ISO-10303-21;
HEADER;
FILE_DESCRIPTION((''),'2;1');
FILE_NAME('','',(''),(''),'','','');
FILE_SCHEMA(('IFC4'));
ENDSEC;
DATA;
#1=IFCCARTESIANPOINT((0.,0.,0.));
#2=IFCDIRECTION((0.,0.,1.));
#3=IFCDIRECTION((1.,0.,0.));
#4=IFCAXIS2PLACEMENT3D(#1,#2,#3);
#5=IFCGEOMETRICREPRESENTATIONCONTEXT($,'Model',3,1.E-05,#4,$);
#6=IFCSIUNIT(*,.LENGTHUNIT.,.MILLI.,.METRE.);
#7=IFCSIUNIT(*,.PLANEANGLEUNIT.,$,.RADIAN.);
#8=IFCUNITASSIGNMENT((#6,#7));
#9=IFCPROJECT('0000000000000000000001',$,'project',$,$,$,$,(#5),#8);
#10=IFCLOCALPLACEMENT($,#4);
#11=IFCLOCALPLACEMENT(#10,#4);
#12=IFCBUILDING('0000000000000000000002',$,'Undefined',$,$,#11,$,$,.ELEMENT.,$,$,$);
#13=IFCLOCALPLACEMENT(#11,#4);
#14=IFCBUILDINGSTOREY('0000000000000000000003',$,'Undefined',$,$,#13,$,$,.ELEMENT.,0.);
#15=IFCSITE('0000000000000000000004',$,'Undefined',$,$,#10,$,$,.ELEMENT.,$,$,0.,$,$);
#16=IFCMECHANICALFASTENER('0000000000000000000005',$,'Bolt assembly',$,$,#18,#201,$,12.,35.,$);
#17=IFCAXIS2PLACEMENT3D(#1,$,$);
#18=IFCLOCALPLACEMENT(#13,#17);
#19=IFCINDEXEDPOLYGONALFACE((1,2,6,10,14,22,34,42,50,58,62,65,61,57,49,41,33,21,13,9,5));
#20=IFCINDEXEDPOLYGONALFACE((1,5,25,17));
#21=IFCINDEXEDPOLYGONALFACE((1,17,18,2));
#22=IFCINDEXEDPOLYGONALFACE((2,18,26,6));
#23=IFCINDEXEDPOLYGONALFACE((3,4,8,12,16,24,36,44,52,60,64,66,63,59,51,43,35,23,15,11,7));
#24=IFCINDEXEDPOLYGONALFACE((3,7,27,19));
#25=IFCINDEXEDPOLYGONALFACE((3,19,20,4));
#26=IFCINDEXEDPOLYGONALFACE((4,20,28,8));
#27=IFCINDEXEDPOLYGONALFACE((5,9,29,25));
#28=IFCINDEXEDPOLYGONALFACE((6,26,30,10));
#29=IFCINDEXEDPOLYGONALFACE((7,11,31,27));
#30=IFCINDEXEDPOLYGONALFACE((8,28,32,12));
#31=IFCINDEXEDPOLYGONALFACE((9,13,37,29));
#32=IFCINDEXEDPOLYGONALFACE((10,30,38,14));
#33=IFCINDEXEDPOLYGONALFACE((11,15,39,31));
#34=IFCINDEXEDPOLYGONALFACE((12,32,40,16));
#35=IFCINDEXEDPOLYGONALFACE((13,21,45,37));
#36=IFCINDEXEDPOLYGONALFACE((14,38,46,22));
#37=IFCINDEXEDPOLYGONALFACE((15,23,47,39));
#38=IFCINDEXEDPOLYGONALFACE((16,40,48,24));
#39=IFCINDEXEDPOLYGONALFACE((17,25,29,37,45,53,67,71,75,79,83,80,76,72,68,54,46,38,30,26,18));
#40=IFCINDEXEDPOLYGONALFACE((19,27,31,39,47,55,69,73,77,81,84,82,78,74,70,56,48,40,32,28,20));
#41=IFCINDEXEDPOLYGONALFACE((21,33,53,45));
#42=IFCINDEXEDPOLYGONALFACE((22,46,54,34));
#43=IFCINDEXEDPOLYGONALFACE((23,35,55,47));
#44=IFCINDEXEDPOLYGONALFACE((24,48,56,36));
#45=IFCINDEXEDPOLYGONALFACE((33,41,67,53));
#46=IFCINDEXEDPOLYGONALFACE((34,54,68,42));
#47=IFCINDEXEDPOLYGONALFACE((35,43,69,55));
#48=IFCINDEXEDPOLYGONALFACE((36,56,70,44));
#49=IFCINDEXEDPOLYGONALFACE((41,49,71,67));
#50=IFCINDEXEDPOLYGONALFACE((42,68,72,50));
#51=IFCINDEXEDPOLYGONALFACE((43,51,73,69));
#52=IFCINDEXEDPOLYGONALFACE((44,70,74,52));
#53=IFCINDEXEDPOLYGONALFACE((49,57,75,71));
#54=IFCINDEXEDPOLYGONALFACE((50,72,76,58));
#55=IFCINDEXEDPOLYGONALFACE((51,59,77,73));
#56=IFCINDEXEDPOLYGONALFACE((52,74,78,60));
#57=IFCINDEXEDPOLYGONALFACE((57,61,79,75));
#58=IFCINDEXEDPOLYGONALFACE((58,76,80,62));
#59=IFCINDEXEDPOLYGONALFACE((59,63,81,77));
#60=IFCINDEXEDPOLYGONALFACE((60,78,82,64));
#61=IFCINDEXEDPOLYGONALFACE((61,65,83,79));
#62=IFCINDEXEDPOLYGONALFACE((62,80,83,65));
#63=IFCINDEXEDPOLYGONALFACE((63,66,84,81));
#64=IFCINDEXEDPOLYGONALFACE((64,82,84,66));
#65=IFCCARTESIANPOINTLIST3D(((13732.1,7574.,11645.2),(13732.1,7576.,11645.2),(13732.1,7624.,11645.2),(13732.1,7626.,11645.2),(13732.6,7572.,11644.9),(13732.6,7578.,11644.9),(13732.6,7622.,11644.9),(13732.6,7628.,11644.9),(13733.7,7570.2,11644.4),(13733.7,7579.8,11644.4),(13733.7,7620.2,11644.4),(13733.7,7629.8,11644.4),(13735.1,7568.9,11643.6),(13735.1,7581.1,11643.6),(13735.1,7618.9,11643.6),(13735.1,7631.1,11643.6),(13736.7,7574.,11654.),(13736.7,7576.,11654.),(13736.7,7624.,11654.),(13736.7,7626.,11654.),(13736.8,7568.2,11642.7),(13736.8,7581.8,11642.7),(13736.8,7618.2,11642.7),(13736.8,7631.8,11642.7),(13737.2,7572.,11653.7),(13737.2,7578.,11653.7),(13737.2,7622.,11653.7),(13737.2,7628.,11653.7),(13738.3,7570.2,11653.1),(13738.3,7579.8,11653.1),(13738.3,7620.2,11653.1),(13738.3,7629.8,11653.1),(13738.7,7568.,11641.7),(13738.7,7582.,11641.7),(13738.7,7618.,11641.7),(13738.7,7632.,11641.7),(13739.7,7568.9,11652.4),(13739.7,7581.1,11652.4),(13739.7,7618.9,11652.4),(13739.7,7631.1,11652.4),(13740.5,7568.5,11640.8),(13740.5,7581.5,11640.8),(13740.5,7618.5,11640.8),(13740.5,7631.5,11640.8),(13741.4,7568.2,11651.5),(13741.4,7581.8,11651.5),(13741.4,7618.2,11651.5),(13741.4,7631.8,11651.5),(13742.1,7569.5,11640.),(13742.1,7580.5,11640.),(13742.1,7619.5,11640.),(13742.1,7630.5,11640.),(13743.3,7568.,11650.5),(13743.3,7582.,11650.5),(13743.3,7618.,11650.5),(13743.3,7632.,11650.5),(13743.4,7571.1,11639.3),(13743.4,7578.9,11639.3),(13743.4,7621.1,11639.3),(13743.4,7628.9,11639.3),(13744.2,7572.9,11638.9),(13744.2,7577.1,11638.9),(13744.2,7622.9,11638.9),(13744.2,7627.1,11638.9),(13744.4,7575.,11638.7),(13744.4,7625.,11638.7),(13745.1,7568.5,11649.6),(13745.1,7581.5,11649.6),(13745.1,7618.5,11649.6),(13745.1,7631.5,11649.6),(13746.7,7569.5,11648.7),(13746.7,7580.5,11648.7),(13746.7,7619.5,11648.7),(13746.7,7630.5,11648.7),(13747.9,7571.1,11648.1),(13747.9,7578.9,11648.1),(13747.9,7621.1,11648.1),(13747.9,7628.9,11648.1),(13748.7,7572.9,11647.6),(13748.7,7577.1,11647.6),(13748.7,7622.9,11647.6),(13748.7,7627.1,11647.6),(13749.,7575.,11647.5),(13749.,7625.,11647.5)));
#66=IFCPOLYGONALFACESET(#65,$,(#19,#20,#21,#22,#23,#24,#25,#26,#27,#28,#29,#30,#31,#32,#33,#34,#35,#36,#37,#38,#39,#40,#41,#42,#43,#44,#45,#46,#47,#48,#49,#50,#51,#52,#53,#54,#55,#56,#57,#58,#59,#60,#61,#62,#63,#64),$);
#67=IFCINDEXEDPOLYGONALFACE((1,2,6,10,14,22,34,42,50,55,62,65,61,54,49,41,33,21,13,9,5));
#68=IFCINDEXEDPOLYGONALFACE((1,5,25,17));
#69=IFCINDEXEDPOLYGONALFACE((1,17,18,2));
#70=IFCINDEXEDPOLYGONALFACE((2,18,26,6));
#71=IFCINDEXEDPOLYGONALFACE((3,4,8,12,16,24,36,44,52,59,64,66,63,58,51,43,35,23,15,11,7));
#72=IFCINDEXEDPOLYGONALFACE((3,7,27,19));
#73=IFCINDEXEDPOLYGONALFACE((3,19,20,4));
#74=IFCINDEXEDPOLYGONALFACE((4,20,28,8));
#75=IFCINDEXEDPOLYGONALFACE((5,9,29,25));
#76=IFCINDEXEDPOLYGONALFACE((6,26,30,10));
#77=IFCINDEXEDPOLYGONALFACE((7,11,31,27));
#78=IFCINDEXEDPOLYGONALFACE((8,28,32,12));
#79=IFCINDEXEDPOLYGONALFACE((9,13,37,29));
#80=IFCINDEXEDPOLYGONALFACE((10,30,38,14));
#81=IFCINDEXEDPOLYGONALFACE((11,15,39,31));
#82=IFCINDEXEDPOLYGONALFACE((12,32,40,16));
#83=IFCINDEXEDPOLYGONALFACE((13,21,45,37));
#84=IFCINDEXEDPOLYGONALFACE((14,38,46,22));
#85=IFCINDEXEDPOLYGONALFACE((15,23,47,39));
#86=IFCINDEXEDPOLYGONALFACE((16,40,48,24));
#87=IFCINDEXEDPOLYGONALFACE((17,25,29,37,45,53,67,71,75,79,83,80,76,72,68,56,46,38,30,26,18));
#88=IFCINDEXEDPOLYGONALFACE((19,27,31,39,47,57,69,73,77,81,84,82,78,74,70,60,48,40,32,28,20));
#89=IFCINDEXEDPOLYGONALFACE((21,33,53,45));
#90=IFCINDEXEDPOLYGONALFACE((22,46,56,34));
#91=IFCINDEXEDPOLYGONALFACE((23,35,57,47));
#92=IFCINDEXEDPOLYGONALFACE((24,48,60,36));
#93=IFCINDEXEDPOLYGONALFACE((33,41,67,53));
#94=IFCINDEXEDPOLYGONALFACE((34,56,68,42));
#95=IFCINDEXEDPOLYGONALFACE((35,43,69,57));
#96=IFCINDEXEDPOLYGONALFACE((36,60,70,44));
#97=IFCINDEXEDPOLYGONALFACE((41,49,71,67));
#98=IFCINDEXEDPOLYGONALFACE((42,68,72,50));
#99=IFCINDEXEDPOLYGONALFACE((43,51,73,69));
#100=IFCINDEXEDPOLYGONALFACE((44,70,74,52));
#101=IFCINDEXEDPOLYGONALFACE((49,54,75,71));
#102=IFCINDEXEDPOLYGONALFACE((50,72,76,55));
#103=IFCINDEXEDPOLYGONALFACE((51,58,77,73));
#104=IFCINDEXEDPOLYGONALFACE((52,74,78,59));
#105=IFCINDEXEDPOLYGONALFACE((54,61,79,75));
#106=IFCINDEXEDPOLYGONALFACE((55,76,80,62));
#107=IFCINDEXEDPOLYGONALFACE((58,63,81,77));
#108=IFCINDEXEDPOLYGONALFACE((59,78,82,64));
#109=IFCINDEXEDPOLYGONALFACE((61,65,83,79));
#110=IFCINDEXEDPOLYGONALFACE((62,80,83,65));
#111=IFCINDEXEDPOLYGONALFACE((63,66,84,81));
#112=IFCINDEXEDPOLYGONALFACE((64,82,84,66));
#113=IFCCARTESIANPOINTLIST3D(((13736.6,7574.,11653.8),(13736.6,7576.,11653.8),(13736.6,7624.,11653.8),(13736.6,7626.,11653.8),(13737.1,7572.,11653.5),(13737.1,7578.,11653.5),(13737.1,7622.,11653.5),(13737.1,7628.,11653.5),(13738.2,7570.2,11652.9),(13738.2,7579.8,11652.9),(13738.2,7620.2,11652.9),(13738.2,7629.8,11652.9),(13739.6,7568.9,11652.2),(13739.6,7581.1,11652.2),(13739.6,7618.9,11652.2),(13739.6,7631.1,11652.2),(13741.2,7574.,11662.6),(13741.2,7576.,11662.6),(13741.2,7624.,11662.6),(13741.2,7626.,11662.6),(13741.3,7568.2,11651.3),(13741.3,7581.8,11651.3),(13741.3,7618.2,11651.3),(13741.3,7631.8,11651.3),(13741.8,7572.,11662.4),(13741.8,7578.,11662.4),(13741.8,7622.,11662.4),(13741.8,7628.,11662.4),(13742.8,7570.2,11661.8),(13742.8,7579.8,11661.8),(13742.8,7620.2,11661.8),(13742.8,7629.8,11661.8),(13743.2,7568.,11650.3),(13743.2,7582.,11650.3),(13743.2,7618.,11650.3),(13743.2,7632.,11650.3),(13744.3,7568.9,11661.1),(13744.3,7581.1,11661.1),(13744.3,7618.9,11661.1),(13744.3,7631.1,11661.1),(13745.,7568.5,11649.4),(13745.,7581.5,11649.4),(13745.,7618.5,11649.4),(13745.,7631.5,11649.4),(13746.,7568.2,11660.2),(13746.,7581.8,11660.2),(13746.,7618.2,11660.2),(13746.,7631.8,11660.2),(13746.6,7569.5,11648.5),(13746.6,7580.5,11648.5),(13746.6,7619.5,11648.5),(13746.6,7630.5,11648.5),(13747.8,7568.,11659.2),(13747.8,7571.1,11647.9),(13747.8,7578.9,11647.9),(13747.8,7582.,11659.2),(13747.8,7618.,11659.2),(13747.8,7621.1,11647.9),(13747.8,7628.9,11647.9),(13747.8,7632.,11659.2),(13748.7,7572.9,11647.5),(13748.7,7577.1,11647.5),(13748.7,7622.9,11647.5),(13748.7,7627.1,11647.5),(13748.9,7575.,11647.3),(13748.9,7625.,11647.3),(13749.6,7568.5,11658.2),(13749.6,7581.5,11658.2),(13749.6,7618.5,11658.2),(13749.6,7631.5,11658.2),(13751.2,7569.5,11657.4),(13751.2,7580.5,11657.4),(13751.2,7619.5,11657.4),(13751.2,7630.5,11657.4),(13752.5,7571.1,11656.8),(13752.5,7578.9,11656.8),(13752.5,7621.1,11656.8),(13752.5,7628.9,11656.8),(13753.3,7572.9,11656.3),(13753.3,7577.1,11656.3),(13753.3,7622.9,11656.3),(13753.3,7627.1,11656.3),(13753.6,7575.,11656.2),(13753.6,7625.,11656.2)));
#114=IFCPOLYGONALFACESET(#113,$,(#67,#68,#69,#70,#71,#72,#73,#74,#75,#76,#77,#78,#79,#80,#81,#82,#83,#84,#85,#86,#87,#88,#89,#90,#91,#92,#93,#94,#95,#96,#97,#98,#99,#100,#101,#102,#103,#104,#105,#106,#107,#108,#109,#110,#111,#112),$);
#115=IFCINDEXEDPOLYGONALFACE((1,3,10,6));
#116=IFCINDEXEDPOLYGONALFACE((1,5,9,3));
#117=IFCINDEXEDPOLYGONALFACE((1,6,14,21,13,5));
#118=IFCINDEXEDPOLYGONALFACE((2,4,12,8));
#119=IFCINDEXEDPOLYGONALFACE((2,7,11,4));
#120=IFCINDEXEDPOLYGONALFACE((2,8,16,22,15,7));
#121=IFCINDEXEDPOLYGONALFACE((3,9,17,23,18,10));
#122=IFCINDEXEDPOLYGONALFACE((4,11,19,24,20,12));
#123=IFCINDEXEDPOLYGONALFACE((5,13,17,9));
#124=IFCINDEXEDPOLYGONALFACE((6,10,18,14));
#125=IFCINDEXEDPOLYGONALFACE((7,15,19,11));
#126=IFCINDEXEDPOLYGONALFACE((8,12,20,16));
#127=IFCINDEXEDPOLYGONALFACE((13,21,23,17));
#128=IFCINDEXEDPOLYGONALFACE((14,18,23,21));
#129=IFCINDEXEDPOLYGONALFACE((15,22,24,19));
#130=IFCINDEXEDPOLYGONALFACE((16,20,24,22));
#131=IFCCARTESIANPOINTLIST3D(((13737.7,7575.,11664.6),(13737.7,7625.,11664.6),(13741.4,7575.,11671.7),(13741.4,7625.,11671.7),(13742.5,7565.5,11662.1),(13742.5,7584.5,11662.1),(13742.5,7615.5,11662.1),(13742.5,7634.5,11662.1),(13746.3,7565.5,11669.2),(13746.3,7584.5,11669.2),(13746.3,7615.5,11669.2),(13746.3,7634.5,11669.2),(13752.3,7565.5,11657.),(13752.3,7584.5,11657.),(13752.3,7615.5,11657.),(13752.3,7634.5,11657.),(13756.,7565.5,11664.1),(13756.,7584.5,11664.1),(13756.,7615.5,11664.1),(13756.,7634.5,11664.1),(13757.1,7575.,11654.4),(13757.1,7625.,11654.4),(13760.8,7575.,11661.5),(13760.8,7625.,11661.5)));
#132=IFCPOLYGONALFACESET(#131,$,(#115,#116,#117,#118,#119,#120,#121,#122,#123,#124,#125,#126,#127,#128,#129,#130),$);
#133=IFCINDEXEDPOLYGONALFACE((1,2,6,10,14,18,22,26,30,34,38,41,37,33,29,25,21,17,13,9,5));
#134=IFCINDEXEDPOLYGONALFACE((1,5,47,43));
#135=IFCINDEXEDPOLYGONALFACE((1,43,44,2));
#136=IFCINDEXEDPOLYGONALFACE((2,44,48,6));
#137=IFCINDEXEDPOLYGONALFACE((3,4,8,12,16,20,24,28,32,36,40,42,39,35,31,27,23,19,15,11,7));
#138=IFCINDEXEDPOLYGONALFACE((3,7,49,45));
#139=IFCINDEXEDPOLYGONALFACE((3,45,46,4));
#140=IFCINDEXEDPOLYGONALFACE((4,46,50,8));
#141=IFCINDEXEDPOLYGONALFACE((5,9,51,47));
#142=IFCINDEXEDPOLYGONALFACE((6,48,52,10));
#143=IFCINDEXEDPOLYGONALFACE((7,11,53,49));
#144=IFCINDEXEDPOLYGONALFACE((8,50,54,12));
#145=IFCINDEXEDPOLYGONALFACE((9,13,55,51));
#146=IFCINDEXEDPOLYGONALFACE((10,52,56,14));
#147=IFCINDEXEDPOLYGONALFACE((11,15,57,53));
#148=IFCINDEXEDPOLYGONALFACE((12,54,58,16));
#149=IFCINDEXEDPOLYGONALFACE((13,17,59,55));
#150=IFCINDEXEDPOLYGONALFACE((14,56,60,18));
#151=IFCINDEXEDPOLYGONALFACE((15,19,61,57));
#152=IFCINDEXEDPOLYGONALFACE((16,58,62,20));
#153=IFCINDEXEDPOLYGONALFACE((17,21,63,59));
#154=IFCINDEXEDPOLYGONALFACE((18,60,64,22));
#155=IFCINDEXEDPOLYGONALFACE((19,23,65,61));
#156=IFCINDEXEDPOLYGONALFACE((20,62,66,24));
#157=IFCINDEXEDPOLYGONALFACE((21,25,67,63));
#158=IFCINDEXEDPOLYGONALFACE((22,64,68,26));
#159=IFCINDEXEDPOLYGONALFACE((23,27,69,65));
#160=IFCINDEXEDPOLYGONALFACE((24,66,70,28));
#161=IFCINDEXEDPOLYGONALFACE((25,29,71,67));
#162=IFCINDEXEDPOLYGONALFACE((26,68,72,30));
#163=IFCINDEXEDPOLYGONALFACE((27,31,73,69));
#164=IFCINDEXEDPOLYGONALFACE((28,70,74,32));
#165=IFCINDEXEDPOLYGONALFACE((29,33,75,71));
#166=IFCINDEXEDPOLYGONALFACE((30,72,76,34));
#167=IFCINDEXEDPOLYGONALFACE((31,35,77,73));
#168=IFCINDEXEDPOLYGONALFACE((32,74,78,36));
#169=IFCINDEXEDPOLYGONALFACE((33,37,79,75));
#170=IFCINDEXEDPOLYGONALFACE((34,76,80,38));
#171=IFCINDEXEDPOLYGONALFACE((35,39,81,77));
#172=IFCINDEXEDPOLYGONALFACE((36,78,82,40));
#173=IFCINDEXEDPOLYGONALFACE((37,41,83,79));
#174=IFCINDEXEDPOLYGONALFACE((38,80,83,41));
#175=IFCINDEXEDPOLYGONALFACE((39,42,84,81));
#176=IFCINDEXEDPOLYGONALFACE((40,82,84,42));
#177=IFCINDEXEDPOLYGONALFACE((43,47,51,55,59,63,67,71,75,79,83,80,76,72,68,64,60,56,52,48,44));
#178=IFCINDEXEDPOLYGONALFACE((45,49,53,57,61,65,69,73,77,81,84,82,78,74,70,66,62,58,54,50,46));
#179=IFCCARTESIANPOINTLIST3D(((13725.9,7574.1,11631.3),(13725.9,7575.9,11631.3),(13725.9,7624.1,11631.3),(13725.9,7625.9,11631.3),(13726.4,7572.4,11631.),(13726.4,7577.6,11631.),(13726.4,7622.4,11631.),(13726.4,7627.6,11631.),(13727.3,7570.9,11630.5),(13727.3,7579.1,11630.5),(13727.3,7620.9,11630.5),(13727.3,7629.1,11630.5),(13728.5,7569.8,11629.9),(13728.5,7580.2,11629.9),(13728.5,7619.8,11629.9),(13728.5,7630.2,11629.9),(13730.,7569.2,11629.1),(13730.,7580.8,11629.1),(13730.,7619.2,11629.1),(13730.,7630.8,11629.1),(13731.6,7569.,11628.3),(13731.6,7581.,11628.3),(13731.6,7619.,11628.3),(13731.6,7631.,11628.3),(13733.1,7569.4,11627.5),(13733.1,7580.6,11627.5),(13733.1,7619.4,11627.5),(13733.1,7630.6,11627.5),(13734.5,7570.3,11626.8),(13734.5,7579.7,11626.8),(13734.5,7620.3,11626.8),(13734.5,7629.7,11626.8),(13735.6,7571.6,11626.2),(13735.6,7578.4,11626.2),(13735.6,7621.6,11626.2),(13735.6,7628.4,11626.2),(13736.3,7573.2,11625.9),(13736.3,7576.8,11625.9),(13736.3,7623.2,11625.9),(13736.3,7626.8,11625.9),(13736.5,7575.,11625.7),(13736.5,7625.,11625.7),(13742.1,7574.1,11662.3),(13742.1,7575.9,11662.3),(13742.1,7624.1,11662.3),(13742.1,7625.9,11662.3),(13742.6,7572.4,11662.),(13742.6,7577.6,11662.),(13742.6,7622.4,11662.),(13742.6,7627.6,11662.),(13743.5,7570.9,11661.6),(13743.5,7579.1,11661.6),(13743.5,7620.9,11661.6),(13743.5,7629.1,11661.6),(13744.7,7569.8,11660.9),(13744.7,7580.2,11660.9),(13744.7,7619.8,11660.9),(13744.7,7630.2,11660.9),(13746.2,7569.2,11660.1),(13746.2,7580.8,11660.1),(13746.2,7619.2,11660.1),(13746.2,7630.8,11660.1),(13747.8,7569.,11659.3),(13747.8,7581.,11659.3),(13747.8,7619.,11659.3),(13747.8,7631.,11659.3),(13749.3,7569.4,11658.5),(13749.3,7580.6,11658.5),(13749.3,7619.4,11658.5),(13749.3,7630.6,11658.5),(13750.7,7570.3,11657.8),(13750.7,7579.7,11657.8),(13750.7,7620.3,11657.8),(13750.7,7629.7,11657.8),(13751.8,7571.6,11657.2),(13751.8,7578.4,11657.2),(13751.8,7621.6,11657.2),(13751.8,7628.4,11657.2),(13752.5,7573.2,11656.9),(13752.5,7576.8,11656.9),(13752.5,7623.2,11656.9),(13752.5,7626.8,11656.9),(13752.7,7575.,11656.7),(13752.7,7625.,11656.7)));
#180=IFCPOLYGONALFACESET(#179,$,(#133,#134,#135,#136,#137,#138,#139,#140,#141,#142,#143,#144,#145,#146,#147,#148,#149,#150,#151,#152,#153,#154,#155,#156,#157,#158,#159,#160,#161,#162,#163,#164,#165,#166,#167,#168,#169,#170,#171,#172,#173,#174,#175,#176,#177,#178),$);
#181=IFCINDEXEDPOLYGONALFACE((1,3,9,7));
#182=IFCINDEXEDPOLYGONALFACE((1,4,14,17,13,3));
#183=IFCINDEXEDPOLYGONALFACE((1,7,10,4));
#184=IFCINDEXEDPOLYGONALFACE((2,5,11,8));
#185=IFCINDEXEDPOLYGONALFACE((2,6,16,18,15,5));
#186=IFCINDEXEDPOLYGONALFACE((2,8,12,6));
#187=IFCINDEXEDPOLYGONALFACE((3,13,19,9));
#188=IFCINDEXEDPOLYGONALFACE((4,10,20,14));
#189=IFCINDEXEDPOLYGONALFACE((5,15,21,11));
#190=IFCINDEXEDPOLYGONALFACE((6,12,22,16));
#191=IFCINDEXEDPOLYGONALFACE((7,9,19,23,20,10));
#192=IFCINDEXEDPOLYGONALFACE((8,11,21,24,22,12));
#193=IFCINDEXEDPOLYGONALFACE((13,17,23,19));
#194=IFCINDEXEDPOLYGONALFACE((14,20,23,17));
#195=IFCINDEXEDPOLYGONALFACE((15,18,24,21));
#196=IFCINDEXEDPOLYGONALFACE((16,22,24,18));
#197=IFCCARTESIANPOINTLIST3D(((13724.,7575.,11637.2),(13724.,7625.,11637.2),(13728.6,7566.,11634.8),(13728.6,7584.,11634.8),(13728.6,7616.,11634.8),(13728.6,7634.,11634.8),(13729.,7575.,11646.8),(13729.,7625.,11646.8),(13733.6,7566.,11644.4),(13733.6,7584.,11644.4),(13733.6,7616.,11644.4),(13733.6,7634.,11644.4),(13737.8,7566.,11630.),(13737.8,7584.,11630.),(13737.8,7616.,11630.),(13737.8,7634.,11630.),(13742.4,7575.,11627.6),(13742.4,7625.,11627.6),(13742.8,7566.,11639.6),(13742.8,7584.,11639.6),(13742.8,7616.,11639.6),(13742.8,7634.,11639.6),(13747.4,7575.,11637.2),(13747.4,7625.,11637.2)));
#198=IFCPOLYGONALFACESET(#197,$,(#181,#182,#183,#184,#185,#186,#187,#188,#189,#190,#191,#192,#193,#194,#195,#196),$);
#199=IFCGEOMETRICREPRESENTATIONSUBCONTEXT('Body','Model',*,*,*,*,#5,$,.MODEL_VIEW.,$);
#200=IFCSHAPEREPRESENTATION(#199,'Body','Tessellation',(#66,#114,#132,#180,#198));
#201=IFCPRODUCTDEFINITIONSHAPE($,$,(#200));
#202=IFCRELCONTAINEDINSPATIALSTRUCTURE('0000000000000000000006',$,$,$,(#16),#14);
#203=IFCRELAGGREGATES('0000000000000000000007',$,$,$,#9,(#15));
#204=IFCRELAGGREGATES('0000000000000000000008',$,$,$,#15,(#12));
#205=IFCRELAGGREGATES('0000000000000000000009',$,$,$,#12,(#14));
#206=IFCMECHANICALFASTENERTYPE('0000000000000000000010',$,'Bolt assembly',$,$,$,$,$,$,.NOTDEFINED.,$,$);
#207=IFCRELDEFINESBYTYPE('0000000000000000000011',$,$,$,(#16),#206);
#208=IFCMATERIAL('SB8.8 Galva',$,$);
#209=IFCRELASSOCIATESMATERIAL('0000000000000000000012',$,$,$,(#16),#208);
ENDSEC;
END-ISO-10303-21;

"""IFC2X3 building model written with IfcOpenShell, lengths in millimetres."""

from ifc_helpers import new_model, si_unit, frame, origin_with_axes, origin_2d_with_axis, place, context, subcontext, project, spatial, polyline, circle, outline, extrude, source, transform, mapped, material, type_object, element, save


model = new_model("IFC2X3")

# Units and contexts
model_context = context("Model", 3, precision=1e-05, world=origin_with_axes())
body_context = subcontext(model_context, "Body", "Model", "MODEL_VIEW")
ifc_project = project(units=[si_unit("LENGTHUNIT", "METRE", prefix="MILLI"), si_unit("PLANEANGLEUNIT", "RADIAN")], contexts=[model_context])

# Site, building, storey
site_placement = place(None, origin_with_axes())
site = spatial("IfcSite", under=ifc_project, at=site_placement, Name="Undefined", CompositionType="ELEMENT", RefElevation=0.0)
building_placement = place(site_placement, origin_with_axes())
building = spatial("IfcBuilding", under=site, at=building_placement, Name="Undefined", CompositionType="ELEMENT")
storey_placement = place(building_placement, origin_with_axes())
storey = spatial("IfcBuildingStorey", under=building, at=storey_placement, Name="Undefined", CompositionType="ELEMENT", Elevation=0.0)

# Mechanical fastener
ifc_material_1 = material(Name="SB8.8 Galva")
mechanical_fastener_type = type_object("IfcMechanicalFastenerType", Name="Bolt assembly")
shared_shape_1 = source(origin_with_axes(), body_context, "Body", "SweptSolid", [
    extrude(circle(Radius=7.0, at=origin_2d_with_axis()), frame((0.0, -0.1, 0.0), z_axis=(0.0, 1.0, 0.0), x_axis=(1.0, 0.0, 0.0)), (0.0, 0.0, 1.0), 9.9),
    extrude(circle(Radius=7.0, at=origin_2d_with_axis()), frame((0.0, -9.9, 0.0), z_axis=(0.0, 1.0, 0.0), x_axis=(1.0, 0.0, 0.0)), (0.0, 0.0, 1.0), 10.0),
    extrude(outline(polyline([(11.0, 0.0), (5.5, 9.5), (-5.5, 9.5), (-11.0, 0.0), (-5.5, -9.5), (5.5, -9.5), (11.0, 0.0)])), frame((0.0, -18.0, 0.0), z_axis=(0.0, 1.0, 0.0), x_axis=(1.0, 0.0, 0.0)), (0.0, 0.0, 1.0), 8.0),
    extrude(circle(Radius=6.0, at=origin_2d_with_axis()), frame((0.0, -10.0, 0.0), z_axis=(0.0, 1.0, 0.0), x_axis=(1.0, 0.0, 0.0)), (0.0, 0.0, 1.0), 35.0),
    extrude(outline(polyline([(10.4, 0.0), (5.2, 9.0), (-5.2, 9.0), (-10.4, 0.0), (-5.2, -9.0), (5.2, -9.0), (10.4, 0.0)])), frame((0.0, 9.8, 0.0), z_axis=(0.0, 1.0, 0.0), x_axis=(1.0, 0.0, 0.0)), (0.0, 0.0, 1.0), 10.8),
])
for number, where, z_axis, x_axis, name in (
    (1, (13742.8, 7600.0, 11650.7), (0.0, 1.0, 0.0), (0.886082, 0.0, -0.463529), "Bolt assembly"),
):
    element("IfcMechanicalFastener", number, at=place(storey_placement, frame(where, z_axis=z_axis, x_axis=x_axis)), inside=storey, type_object=mechanical_fastener_type, material=ifc_material_1, Name=name, NominalDiameter=12.0, NominalLength=35.0, context=body_context, shape_type="MappedRepresentation", body=[
        mapped(shared_shape_1, transform((0.0, 0.0, -25.0))),
        mapped(shared_shape_1, transform((0.0, 0.0, 25.0))),
    ])

save(model, "model.ifc")
